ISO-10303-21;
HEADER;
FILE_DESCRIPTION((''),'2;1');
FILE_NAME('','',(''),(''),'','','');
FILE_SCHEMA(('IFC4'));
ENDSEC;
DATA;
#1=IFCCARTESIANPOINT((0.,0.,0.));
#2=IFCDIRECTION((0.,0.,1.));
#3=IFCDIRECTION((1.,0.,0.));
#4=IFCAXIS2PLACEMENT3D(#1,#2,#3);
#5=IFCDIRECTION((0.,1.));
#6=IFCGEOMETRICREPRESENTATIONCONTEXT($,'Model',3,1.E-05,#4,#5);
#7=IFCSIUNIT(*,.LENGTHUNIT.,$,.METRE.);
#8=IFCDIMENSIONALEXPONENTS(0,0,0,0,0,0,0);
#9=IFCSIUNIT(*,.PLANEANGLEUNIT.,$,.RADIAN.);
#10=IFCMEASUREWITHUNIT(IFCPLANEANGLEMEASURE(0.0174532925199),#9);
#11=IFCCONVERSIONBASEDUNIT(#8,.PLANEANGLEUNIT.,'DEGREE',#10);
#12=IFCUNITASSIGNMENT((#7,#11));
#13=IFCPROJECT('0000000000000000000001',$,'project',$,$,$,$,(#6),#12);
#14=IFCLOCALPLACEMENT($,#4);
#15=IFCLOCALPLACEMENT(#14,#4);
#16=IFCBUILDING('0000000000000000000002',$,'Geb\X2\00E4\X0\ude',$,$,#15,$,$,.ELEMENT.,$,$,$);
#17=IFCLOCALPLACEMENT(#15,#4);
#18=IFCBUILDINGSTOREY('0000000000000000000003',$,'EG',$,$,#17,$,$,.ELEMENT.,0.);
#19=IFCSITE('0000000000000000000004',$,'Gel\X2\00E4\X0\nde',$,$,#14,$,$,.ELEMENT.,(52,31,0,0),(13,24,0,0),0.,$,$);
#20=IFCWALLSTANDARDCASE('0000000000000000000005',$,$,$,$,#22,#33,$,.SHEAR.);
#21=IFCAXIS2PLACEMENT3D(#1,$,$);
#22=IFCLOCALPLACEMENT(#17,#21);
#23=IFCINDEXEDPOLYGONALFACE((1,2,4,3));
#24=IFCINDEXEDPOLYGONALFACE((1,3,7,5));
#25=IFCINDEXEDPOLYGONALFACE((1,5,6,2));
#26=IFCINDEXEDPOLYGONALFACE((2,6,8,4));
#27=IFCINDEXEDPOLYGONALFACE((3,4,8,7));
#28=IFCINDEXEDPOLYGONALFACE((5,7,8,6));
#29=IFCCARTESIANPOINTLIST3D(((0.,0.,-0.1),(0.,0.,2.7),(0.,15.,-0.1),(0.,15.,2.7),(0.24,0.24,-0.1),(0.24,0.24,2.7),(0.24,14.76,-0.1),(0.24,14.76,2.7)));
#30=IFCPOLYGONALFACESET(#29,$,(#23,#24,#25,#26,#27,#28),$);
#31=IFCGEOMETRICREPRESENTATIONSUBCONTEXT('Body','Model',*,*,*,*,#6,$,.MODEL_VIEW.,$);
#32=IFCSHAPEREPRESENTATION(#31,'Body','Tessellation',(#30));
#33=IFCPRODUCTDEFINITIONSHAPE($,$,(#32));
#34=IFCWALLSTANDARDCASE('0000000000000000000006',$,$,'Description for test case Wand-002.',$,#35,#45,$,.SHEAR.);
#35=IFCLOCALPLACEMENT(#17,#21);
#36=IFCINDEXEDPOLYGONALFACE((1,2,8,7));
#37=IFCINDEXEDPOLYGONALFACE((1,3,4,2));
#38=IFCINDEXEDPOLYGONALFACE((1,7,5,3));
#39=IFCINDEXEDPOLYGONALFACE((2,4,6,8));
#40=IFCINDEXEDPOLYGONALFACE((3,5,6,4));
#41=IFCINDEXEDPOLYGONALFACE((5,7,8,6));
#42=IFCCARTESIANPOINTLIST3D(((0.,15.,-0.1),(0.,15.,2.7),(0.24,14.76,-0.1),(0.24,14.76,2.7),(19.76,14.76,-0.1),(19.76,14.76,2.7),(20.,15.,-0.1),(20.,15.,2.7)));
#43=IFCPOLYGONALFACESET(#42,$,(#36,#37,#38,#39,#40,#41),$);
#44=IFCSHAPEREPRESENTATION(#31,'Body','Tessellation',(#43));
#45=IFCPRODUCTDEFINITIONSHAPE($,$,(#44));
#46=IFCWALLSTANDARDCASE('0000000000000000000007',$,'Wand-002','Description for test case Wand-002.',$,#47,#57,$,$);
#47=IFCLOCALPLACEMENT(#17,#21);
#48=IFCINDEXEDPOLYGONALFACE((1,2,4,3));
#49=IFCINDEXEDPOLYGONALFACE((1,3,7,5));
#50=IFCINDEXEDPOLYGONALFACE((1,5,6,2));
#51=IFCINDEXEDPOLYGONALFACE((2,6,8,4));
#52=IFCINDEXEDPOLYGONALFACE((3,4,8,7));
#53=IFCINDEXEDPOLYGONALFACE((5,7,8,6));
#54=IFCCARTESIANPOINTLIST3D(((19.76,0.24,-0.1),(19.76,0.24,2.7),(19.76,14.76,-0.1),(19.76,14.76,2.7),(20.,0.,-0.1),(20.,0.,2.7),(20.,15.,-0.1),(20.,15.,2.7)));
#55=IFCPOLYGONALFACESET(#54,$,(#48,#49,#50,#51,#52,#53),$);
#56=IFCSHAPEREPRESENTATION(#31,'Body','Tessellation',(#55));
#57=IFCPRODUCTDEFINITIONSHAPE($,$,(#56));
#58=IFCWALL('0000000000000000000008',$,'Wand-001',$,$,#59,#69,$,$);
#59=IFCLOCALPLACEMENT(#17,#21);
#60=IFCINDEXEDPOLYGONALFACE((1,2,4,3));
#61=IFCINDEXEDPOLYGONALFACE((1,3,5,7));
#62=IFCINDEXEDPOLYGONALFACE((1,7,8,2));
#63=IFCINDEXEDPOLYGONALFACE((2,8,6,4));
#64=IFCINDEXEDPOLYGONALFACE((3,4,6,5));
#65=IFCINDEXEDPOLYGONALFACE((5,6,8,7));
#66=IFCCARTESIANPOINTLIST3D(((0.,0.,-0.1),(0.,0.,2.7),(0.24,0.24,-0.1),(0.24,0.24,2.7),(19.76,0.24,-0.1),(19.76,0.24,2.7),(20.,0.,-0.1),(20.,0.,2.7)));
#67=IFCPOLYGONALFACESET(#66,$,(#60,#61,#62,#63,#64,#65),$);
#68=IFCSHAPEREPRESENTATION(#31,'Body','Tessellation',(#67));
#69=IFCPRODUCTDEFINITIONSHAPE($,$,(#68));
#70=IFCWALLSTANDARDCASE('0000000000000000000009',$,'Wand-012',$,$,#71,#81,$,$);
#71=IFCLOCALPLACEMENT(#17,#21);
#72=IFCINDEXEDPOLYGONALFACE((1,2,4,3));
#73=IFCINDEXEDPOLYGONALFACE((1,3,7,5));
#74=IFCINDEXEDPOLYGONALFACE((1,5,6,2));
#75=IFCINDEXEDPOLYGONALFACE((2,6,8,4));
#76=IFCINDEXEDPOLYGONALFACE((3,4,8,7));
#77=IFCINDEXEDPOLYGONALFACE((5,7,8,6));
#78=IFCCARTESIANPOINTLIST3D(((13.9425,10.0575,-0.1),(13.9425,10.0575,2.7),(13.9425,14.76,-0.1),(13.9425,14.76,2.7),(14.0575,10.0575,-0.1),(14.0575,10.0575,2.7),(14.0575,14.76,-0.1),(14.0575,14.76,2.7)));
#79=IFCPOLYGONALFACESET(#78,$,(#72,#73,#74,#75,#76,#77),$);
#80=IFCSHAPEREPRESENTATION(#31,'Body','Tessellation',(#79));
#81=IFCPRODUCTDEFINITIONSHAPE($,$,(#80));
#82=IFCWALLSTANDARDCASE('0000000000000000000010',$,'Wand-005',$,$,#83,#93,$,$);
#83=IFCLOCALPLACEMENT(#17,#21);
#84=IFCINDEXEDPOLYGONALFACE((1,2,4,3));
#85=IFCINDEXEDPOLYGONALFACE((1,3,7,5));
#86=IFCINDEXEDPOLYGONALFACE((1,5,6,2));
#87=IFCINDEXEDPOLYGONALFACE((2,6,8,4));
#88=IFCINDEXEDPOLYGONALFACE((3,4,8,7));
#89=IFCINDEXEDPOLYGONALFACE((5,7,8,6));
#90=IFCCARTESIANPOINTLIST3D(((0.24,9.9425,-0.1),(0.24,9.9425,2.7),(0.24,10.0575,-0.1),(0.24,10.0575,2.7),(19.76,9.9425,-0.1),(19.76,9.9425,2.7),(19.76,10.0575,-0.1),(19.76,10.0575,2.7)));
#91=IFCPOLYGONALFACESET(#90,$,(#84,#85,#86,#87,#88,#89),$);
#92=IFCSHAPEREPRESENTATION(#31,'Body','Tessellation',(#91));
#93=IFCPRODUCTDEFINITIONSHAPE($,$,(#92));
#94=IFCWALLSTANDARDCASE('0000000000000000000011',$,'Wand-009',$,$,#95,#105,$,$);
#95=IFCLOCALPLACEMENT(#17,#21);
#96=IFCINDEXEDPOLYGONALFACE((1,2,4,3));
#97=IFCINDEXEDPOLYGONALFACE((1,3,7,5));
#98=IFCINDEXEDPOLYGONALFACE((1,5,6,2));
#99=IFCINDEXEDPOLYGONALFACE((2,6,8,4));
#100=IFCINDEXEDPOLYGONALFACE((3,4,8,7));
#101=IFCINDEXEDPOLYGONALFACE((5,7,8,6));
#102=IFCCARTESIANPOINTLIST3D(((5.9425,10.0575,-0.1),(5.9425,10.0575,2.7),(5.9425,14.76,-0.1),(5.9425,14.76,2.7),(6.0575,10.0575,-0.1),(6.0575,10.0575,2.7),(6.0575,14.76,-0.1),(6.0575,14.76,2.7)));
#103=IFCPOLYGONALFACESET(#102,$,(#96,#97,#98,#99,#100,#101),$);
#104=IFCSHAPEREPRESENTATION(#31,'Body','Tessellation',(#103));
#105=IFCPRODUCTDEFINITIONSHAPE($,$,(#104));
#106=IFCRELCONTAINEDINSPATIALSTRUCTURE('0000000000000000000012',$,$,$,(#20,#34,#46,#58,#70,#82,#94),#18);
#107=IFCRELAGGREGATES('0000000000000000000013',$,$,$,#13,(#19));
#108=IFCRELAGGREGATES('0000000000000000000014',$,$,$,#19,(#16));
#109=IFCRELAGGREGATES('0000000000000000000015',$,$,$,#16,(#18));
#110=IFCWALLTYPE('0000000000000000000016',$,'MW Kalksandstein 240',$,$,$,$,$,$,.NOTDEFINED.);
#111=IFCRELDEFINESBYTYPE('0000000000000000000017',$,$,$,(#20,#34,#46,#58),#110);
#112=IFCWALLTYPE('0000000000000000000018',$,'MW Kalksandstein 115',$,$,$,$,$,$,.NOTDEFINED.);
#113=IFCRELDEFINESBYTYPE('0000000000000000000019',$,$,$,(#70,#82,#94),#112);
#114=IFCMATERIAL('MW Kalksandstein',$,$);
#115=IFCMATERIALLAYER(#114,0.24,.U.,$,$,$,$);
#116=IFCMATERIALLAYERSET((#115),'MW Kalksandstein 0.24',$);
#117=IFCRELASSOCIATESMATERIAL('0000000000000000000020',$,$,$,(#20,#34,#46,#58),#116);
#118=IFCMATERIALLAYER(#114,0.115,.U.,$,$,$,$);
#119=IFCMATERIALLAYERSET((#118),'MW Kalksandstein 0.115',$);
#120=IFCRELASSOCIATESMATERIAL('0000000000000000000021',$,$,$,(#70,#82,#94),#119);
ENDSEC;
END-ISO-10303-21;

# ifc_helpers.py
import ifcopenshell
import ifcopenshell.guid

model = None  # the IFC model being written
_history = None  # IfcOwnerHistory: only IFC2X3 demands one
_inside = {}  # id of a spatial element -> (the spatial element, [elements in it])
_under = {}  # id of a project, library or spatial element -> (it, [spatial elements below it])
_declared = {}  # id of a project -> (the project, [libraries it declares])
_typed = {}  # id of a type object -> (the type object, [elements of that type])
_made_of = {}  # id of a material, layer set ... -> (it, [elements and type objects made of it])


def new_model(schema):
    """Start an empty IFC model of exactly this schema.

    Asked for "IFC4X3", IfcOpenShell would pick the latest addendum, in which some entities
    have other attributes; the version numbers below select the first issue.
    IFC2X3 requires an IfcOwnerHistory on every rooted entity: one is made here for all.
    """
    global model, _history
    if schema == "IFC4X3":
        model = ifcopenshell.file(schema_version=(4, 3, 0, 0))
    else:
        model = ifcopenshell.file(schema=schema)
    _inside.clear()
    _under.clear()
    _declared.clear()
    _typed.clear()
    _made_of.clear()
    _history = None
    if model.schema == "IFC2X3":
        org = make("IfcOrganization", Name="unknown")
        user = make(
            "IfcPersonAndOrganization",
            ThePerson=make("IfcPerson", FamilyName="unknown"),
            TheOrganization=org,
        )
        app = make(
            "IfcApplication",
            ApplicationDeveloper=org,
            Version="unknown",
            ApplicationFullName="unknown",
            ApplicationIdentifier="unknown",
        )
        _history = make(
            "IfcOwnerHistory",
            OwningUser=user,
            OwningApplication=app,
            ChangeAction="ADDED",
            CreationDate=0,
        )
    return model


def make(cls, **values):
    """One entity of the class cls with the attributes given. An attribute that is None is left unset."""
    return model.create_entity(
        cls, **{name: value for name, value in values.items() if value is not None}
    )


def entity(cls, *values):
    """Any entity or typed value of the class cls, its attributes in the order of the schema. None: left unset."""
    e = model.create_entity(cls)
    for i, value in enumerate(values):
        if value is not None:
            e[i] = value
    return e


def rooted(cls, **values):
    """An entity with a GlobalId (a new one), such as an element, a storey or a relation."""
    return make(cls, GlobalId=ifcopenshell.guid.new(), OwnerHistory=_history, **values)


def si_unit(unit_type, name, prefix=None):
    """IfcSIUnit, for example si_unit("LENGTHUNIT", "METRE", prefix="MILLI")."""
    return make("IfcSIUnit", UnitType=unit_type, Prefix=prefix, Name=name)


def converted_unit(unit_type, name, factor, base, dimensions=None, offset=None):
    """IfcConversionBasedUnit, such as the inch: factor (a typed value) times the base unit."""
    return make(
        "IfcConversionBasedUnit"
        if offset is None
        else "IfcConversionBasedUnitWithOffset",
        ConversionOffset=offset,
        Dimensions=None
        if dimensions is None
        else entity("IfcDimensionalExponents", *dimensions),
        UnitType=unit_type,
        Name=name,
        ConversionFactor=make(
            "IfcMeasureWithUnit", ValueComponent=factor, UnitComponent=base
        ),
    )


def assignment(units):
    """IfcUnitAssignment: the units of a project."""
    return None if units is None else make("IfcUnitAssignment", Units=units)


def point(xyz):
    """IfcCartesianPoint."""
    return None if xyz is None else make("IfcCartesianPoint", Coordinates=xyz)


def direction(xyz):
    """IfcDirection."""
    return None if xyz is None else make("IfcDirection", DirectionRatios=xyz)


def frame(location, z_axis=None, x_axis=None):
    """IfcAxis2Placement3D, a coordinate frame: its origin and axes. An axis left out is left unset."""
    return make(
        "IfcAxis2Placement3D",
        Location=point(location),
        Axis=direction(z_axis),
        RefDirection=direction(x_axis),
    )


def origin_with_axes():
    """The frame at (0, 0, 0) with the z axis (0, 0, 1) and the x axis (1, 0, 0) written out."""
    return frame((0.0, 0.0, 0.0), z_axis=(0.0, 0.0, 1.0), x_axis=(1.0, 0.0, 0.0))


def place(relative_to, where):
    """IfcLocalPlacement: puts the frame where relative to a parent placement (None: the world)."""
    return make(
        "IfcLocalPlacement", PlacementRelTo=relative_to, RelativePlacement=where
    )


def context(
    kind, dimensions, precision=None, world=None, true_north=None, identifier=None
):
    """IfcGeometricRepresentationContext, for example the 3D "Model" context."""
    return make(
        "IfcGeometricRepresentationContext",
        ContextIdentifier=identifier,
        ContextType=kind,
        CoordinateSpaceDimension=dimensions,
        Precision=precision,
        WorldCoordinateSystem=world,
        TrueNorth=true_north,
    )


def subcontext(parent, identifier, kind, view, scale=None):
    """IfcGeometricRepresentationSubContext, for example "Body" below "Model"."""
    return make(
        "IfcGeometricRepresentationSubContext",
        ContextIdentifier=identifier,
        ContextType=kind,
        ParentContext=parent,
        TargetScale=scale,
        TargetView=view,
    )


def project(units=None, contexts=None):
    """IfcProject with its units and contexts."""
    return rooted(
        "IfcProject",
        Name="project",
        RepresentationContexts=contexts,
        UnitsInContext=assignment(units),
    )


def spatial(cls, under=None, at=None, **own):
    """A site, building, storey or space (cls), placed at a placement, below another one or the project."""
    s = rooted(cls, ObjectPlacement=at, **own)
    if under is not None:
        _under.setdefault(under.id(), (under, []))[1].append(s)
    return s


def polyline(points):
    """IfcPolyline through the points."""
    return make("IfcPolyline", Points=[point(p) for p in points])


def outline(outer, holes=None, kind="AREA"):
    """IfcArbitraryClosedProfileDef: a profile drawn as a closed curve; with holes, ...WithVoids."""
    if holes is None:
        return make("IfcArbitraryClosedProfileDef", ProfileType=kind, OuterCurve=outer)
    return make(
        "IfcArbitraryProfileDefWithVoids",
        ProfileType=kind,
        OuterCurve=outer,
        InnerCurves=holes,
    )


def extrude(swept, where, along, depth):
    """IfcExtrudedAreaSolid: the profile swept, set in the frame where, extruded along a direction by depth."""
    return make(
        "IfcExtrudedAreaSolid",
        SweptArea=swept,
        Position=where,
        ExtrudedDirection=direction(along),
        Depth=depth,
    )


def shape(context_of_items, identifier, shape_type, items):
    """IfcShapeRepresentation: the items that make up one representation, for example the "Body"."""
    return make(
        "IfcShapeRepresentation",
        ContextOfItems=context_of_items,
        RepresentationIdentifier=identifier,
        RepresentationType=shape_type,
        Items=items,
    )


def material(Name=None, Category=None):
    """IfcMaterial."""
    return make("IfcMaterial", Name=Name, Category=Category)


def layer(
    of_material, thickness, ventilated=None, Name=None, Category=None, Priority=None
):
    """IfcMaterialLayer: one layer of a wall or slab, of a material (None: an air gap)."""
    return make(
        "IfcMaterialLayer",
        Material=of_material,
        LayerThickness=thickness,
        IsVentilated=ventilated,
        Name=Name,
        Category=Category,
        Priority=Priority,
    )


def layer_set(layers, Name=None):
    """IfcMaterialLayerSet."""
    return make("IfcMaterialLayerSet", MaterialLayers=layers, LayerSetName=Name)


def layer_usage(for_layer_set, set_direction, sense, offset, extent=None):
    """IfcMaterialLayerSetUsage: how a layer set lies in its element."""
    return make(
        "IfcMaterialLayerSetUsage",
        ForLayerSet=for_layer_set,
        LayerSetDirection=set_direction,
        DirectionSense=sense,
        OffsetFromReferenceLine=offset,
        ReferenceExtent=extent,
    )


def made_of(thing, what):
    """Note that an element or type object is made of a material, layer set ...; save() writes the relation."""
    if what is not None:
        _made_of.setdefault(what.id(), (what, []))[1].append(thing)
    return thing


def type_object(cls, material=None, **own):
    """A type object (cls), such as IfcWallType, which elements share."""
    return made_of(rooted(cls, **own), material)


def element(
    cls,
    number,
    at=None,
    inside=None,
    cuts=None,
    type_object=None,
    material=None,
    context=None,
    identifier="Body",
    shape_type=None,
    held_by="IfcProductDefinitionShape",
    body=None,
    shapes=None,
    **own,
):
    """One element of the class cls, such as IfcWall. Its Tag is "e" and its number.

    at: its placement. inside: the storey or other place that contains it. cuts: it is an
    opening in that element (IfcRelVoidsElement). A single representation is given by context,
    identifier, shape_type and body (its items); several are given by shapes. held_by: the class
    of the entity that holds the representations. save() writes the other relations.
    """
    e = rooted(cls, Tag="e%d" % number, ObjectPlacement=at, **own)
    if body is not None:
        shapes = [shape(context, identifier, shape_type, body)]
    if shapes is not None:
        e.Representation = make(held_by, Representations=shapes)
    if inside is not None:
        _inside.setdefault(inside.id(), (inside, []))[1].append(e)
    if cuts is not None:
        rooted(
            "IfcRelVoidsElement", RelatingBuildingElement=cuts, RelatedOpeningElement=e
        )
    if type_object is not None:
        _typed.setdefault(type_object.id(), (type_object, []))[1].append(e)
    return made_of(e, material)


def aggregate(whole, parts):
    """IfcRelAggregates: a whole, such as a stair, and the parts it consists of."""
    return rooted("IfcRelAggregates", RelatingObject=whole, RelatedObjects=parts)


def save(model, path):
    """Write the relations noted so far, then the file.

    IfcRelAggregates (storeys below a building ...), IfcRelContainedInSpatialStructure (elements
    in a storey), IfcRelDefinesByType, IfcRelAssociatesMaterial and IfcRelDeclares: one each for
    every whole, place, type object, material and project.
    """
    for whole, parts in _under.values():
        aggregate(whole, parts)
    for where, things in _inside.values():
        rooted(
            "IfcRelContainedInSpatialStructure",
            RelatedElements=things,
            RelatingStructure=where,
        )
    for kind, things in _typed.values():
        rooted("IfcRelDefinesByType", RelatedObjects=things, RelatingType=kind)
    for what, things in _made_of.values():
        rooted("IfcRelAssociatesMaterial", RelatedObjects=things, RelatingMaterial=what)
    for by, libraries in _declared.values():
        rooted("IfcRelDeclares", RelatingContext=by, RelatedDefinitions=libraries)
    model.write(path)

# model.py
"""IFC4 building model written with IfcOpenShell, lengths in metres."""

from ifc_helpers import new_model, entity, si_unit, converted_unit, direction, frame, origin_with_axes, place, context, subcontext, project, spatial, polyline, outline, extrude, material, layer, layer_set, layer_usage, type_object, element, save


model = new_model("IFC4")

# Units and contexts
model_context = context("Model", 3, precision=1e-05, world=origin_with_axes(), true_north=direction((0.0, 1.0)))
body_context = subcontext(model_context, "Body", "Model", "MODEL_VIEW")
ifc_project = project(units=[si_unit("LENGTHUNIT", "METRE"), converted_unit("PLANEANGLEUNIT", "DEGREE", entity("IfcPlaneAngleMeasure", 0.0174532925199), si_unit("PLANEANGLEUNIT", "RADIAN"), dimensions=[0, 0, 0, 0, 0, 0, 0])], contexts=[model_context])

# Site, building, storey
site_placement = place(None, origin_with_axes())
site = spatial("IfcSite", under=ifc_project, at=site_placement, Name="Gelände", CompositionType="ELEMENT", RefLatitude=(52, 31, 0, 0), RefLongitude=(13, 24, 0, 0), RefElevation=0.0)
building_placement = place(site_placement, origin_with_axes())
building = spatial("IfcBuilding", under=site, at=building_placement, Name="Gebäude", CompositionType="ELEMENT")
storey_placement = place(building_placement, origin_with_axes())
storey = spatial("IfcBuildingStorey", under=building, at=storey_placement, Name="EG", CompositionType="ELEMENT", Elevation=0.0)

# Walls
ifc_material = material(Name="MW Kalksandstein")
ifc_layer_1 = layer(ifc_material, 0.24, ventilated="UNKNOWN")
ifc_layer_set_1 = layer_set([ifc_layer_1], Name="MW Kalksandstein 0.24")
ifc_layer_usage_1 = layer_usage(ifc_layer_set_1, "AXIS2", "POSITIVE", 0.0)
wall_type_1 = type_object("IfcWallType", Name="MW Kalksandstein 240", PredefinedType="NOTDEFINED")
wall_1_placement = place(storey_placement, frame((0.0, 15.0, -0.1), z_axis=(0.0, 0.0, 1.0), x_axis=(0.0, -1.0, 0.0)))
element("IfcWallStandardCase", 1, at=wall_1_placement, inside=storey, type_object=wall_type_1, material=ifc_layer_usage_1, PredefinedType="SHEAR", context=body_context, shape_type="SweptSolid", body=[
    extrude(outline(polyline([(0.0, 0.0), (15.0, 0.0), (14.76, 0.24), (0.24, 0.24), (0.0, 0.0)])), origin_with_axes(), (0.0, 0.0, 1.0), 2.8),
])
ifc_layer_usage_2 = layer_usage(ifc_layer_set_1, "AXIS2", "POSITIVE", 0.0)
wall_2_placement = place(storey_placement, frame((20.0, 15.0, -0.1), z_axis=(0.0, 0.0, 1.0), x_axis=(-1.0, 0.0, 0.0)))
element("IfcWallStandardCase", 2, at=wall_2_placement, inside=storey, type_object=wall_type_1, material=ifc_layer_usage_2, Description="Description for test case Wand-002.", PredefinedType="SHEAR", context=body_context, shape_type="SweptSolid", body=[
    extrude(outline(polyline([(0.0, 0.0), (20.0, 0.0), (19.76, 0.24), (0.24, 0.24), (0.0, 0.0)])), origin_with_axes(), (0.0, 0.0, 1.0), 2.8),
])
ifc_layer_usage_3 = layer_usage(ifc_layer_set_1, "AXIS2", "POSITIVE", 0.0)
wall_3_placement = place(storey_placement, frame((20.0, 0.0, -0.1), z_axis=(0.0, 0.0, 1.0), x_axis=(0.0, 1.0, 0.0)))
element("IfcWallStandardCase", 3, at=wall_3_placement, inside=storey, type_object=wall_type_1, material=ifc_layer_usage_3, Name="Wand-002", Description="Description for test case Wand-002.", context=body_context, shape_type="SweptSolid", body=[
    extrude(outline(polyline([(0.0, 0.0), (15.0, 0.0), (14.76, 0.24), (0.24, 0.24), (0.0, 0.0)])), origin_with_axes(), (0.0, 0.0, 1.0), 2.8),
])
ifc_layer_usage_4 = layer_usage(ifc_layer_set_1, "AXIS2", "POSITIVE", 0.0)
wall_4_placement = place(storey_placement, frame((0.0, 0.0, -0.1), z_axis=(0.0, 0.0, 1.0), x_axis=(1.0, 0.0, 0.0)))
element("IfcWall", 4, at=wall_4_placement, inside=storey, type_object=wall_type_1, material=ifc_layer_usage_4, Name="Wand-001", context=body_context, shape_type="SweptSolid", body=[
    extrude(outline(polyline([(0.0, 0.0), (20.0, 0.0), (19.76, 0.24), (0.24, 0.24), (0.0, 0.0)])), origin_with_axes(), (0.0, 0.0, 1.0), 2.8),
])
ifc_layer_2 = layer(ifc_material, 0.115, ventilated="UNKNOWN")
ifc_layer_set_2 = layer_set([ifc_layer_2], Name="MW Kalksandstein 0.115")
ifc_layer_usage_5 = layer_usage(ifc_layer_set_2, "AXIS2", "POSITIVE", -0.0575)
wall_type_2 = type_object("IfcWallType", Name="MW Kalksandstein 115", PredefinedType="NOTDEFINED")
wall_5_placement = place(storey_placement, frame((14.0, 10.0, -0.1), z_axis=(0.0, 0.0, 1.0), x_axis=(0.0, 1.0, 0.0)))
element("IfcWallStandardCase", 5, at=wall_5_placement, inside=storey, type_object=wall_type_2, material=ifc_layer_usage_5, Name="Wand-012", context=body_context, shape_type="SweptSolid", body=[
    extrude(outline(polyline([(0.0575, -0.0575), (4.76, -0.0575), (4.76, 0.0575), (0.0575, 0.0575), (0.0575, -0.0575)])), origin_with_axes(), (0.0, 0.0, 1.0), 2.8),
])
ifc_layer_usage_6 = layer_usage(ifc_layer_set_2, "AXIS2", "POSITIVE", -0.0575)
wall_6_placement = place(storey_placement, frame((0.0, 10.0, -0.1), z_axis=(0.0, 0.0, 1.0), x_axis=(1.0, 0.0, 0.0)))
element("IfcWallStandardCase", 6, at=wall_6_placement, inside=storey, type_object=wall_type_2, material=ifc_layer_usage_6, Name="Wand-005", context=body_context, shape_type="SweptSolid", body=[
    extrude(outline(polyline([(0.24, -0.0575), (19.76, -0.0575), (19.76, 0.0575), (0.24, 0.0575), (0.24, -0.0575)])), origin_with_axes(), (0.0, 0.0, 1.0), 2.8),
])
ifc_layer_usage_7 = layer_usage(ifc_layer_set_2, "AXIS2", "POSITIVE", -0.0575)
wall_7_placement = place(storey_placement, frame((6.0, 10.0, -0.1), z_axis=(0.0, 0.0, 1.0), x_axis=(0.0, 1.0, 0.0)))
element("IfcWallStandardCase", 7, at=wall_7_placement, inside=storey, type_object=wall_type_2, material=ifc_layer_usage_7, Name="Wand-009", context=body_context, shape_type="SweptSolid", body=[
    extrude(outline(polyline([(0.0575, -0.0575), (4.76, -0.0575), (4.76, 0.0575), (0.0575, 0.0575), (0.0575, -0.0575)])), origin_with_axes(), (0.0, 0.0, 1.0), 2.8),
])

save(model, "model.ifc")
